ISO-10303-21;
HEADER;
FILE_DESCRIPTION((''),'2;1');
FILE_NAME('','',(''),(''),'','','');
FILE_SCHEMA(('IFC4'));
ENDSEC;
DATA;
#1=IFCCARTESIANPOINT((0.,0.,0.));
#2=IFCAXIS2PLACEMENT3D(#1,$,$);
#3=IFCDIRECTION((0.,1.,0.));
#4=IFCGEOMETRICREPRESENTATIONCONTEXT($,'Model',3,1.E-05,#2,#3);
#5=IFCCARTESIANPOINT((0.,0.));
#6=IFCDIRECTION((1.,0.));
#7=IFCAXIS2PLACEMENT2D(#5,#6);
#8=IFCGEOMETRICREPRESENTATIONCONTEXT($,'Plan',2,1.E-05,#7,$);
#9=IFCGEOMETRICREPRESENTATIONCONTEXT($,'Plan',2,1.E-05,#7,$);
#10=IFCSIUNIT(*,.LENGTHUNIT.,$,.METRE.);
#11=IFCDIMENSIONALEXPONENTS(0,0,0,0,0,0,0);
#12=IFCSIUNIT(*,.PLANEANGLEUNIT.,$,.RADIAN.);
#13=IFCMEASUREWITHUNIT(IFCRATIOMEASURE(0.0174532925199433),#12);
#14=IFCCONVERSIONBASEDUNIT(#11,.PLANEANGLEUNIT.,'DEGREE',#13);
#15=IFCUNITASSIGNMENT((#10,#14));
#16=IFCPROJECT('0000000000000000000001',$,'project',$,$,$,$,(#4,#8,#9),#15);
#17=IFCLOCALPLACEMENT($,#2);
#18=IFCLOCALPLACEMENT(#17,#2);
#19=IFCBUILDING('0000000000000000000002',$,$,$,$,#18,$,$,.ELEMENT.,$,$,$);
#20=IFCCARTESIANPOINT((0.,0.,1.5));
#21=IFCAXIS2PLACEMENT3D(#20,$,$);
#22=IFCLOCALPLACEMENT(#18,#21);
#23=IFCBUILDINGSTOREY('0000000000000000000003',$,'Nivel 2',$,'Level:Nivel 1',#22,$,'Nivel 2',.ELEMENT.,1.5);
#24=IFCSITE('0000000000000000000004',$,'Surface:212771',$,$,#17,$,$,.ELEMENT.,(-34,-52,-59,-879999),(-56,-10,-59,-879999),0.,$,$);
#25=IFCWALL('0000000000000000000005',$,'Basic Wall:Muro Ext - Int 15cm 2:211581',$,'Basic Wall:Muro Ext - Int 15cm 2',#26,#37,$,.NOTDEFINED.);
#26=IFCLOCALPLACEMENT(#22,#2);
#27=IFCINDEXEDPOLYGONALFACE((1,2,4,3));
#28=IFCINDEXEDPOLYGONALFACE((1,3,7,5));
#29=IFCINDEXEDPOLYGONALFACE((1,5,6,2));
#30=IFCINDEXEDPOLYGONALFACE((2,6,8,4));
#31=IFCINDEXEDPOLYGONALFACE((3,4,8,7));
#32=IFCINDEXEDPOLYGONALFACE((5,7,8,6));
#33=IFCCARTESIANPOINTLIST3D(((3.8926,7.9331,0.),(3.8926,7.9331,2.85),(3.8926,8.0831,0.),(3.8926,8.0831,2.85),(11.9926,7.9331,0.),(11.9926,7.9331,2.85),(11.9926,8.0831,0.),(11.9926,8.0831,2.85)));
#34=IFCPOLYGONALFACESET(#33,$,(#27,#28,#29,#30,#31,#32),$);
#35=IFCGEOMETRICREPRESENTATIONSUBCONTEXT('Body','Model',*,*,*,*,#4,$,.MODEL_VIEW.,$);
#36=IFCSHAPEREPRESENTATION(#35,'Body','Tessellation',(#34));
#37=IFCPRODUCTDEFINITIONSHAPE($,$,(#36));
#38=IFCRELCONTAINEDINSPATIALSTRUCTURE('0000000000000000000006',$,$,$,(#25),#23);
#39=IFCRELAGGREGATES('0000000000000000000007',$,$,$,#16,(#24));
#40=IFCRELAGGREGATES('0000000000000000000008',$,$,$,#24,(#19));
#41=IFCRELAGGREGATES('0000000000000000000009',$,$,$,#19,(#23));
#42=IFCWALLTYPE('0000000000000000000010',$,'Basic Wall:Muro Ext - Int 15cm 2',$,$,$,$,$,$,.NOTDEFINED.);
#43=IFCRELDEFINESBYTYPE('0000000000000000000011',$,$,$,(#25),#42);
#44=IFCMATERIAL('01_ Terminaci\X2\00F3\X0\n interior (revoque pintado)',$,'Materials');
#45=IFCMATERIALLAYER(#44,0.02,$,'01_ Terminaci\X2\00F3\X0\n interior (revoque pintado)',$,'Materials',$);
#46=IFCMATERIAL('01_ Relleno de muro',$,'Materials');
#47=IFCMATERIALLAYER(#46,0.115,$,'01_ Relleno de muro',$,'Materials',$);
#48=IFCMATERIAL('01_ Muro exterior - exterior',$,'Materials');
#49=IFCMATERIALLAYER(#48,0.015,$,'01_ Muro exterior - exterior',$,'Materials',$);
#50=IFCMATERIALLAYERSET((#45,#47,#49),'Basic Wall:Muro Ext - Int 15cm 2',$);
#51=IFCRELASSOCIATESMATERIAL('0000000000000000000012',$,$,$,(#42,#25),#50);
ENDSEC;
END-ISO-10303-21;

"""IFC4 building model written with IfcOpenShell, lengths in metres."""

from ifc_helpers import new_model, entity, si_unit, converted_unit, direction, frame, origin, origin_2d_with_axis, place, context, subcontext, project, spatial, indexed_curve, outline, extrude, material, layer, layer_set, type_object, element, save


model = new_model("IFC4")

# Units and contexts
model_context = context("Model", 3, precision=1e-05, world=origin(), true_north=direction((0.0, 1.0, 0.0)))
plan_context_1 = context("Plan", 2, precision=1e-05, world=origin_2d_with_axis())
plan_context_2 = context("Plan", 2, precision=1e-05, world=origin_2d_with_axis())
body_context = subcontext(model_context, "Body", "Model", "MODEL_VIEW")
ifc_project = project(units=[si_unit("LENGTHUNIT", "METRE"), converted_unit("PLANEANGLEUNIT", "DEGREE", entity("IfcRatioMeasure", 0.0174532925199433), si_unit("PLANEANGLEUNIT", "RADIAN"), dimensions=[0, 0, 0, 0, 0, 0, 0])], contexts=[model_context, plan_context_1, plan_context_2])

# Site, building, storey
site_placement = place(None, origin())
site = spatial("IfcSite", under=ifc_project, at=site_placement, Name="Surface:212771", CompositionType="ELEMENT", RefLatitude=(-34, -52, -59, -879999), RefLongitude=(-56, -10, -59, -879999), RefElevation=0.0)
building_placement = place(site_placement, origin())
building = spatial("IfcBuilding", under=site, at=building_placement, CompositionType="ELEMENT")
storey_placement = place(building_placement, frame((0.0, 0.0, 1.5)))
storey = spatial("IfcBuildingStorey", under=building, at=storey_placement, Name="Nivel 2", ObjectType="Level:Nivel 1", LongName="Nivel 2", CompositionType="ELEMENT", Elevation=1.5)

# Wall
ifc_material_1 = material(Name="01_ Muro exterior - exterior", Category="Materials")
ifc_material_2 = material(Name="01_ Relleno de muro", Category="Materials")
ifc_material_3 = material(Name="01_ Terminación interior (revoque pintado)", Category="Materials")
ifc_layer_1 = layer(ifc_material_3, 0.02, Name="01_ Terminación interior (revoque pintado)", Category="Materials")
ifc_layer_2 = layer(ifc_material_2, 0.115, Name="01_ Relleno de muro", Category="Materials")
ifc_layer_3 = layer(ifc_material_1, 0.015, Name="01_ Muro exterior - exterior", Category="Materials")
ifc_layer_set_1 = layer_set([ifc_layer_1, ifc_layer_2, ifc_layer_3], Name="Basic Wall:Muro Ext - Int 15cm 2")
wall_type_1 = type_object("IfcWallType", Name="Basic Wall:Muro Ext - Int 15cm 2", PredefinedType="NOTDEFINED", material=ifc_layer_set_1)
wall_1_placement = place(storey_placement, frame((3.8926, 8.0081, 0.0)))
element("IfcWall", 1, at=wall_1_placement, inside=storey, type_object=wall_type_1, material=ifc_layer_set_1, Name="Basic Wall:Muro Ext - Int 15cm 2:211581", ObjectType="Basic Wall:Muro Ext - Int 15cm 2", PredefinedType="NOTDEFINED", context=body_context, shape_type="SweptSolid", body=[
    extrude(outline(indexed_curve([(8.1, 0.075), (0.0, 0.075), (0.0, -0.075), (8.1, -0.075), (8.1, 0.075)], self_intersect=False)), origin(), (0.0, 0.0, 1.0), 2.85),
])

save(model, "model.ifc")
